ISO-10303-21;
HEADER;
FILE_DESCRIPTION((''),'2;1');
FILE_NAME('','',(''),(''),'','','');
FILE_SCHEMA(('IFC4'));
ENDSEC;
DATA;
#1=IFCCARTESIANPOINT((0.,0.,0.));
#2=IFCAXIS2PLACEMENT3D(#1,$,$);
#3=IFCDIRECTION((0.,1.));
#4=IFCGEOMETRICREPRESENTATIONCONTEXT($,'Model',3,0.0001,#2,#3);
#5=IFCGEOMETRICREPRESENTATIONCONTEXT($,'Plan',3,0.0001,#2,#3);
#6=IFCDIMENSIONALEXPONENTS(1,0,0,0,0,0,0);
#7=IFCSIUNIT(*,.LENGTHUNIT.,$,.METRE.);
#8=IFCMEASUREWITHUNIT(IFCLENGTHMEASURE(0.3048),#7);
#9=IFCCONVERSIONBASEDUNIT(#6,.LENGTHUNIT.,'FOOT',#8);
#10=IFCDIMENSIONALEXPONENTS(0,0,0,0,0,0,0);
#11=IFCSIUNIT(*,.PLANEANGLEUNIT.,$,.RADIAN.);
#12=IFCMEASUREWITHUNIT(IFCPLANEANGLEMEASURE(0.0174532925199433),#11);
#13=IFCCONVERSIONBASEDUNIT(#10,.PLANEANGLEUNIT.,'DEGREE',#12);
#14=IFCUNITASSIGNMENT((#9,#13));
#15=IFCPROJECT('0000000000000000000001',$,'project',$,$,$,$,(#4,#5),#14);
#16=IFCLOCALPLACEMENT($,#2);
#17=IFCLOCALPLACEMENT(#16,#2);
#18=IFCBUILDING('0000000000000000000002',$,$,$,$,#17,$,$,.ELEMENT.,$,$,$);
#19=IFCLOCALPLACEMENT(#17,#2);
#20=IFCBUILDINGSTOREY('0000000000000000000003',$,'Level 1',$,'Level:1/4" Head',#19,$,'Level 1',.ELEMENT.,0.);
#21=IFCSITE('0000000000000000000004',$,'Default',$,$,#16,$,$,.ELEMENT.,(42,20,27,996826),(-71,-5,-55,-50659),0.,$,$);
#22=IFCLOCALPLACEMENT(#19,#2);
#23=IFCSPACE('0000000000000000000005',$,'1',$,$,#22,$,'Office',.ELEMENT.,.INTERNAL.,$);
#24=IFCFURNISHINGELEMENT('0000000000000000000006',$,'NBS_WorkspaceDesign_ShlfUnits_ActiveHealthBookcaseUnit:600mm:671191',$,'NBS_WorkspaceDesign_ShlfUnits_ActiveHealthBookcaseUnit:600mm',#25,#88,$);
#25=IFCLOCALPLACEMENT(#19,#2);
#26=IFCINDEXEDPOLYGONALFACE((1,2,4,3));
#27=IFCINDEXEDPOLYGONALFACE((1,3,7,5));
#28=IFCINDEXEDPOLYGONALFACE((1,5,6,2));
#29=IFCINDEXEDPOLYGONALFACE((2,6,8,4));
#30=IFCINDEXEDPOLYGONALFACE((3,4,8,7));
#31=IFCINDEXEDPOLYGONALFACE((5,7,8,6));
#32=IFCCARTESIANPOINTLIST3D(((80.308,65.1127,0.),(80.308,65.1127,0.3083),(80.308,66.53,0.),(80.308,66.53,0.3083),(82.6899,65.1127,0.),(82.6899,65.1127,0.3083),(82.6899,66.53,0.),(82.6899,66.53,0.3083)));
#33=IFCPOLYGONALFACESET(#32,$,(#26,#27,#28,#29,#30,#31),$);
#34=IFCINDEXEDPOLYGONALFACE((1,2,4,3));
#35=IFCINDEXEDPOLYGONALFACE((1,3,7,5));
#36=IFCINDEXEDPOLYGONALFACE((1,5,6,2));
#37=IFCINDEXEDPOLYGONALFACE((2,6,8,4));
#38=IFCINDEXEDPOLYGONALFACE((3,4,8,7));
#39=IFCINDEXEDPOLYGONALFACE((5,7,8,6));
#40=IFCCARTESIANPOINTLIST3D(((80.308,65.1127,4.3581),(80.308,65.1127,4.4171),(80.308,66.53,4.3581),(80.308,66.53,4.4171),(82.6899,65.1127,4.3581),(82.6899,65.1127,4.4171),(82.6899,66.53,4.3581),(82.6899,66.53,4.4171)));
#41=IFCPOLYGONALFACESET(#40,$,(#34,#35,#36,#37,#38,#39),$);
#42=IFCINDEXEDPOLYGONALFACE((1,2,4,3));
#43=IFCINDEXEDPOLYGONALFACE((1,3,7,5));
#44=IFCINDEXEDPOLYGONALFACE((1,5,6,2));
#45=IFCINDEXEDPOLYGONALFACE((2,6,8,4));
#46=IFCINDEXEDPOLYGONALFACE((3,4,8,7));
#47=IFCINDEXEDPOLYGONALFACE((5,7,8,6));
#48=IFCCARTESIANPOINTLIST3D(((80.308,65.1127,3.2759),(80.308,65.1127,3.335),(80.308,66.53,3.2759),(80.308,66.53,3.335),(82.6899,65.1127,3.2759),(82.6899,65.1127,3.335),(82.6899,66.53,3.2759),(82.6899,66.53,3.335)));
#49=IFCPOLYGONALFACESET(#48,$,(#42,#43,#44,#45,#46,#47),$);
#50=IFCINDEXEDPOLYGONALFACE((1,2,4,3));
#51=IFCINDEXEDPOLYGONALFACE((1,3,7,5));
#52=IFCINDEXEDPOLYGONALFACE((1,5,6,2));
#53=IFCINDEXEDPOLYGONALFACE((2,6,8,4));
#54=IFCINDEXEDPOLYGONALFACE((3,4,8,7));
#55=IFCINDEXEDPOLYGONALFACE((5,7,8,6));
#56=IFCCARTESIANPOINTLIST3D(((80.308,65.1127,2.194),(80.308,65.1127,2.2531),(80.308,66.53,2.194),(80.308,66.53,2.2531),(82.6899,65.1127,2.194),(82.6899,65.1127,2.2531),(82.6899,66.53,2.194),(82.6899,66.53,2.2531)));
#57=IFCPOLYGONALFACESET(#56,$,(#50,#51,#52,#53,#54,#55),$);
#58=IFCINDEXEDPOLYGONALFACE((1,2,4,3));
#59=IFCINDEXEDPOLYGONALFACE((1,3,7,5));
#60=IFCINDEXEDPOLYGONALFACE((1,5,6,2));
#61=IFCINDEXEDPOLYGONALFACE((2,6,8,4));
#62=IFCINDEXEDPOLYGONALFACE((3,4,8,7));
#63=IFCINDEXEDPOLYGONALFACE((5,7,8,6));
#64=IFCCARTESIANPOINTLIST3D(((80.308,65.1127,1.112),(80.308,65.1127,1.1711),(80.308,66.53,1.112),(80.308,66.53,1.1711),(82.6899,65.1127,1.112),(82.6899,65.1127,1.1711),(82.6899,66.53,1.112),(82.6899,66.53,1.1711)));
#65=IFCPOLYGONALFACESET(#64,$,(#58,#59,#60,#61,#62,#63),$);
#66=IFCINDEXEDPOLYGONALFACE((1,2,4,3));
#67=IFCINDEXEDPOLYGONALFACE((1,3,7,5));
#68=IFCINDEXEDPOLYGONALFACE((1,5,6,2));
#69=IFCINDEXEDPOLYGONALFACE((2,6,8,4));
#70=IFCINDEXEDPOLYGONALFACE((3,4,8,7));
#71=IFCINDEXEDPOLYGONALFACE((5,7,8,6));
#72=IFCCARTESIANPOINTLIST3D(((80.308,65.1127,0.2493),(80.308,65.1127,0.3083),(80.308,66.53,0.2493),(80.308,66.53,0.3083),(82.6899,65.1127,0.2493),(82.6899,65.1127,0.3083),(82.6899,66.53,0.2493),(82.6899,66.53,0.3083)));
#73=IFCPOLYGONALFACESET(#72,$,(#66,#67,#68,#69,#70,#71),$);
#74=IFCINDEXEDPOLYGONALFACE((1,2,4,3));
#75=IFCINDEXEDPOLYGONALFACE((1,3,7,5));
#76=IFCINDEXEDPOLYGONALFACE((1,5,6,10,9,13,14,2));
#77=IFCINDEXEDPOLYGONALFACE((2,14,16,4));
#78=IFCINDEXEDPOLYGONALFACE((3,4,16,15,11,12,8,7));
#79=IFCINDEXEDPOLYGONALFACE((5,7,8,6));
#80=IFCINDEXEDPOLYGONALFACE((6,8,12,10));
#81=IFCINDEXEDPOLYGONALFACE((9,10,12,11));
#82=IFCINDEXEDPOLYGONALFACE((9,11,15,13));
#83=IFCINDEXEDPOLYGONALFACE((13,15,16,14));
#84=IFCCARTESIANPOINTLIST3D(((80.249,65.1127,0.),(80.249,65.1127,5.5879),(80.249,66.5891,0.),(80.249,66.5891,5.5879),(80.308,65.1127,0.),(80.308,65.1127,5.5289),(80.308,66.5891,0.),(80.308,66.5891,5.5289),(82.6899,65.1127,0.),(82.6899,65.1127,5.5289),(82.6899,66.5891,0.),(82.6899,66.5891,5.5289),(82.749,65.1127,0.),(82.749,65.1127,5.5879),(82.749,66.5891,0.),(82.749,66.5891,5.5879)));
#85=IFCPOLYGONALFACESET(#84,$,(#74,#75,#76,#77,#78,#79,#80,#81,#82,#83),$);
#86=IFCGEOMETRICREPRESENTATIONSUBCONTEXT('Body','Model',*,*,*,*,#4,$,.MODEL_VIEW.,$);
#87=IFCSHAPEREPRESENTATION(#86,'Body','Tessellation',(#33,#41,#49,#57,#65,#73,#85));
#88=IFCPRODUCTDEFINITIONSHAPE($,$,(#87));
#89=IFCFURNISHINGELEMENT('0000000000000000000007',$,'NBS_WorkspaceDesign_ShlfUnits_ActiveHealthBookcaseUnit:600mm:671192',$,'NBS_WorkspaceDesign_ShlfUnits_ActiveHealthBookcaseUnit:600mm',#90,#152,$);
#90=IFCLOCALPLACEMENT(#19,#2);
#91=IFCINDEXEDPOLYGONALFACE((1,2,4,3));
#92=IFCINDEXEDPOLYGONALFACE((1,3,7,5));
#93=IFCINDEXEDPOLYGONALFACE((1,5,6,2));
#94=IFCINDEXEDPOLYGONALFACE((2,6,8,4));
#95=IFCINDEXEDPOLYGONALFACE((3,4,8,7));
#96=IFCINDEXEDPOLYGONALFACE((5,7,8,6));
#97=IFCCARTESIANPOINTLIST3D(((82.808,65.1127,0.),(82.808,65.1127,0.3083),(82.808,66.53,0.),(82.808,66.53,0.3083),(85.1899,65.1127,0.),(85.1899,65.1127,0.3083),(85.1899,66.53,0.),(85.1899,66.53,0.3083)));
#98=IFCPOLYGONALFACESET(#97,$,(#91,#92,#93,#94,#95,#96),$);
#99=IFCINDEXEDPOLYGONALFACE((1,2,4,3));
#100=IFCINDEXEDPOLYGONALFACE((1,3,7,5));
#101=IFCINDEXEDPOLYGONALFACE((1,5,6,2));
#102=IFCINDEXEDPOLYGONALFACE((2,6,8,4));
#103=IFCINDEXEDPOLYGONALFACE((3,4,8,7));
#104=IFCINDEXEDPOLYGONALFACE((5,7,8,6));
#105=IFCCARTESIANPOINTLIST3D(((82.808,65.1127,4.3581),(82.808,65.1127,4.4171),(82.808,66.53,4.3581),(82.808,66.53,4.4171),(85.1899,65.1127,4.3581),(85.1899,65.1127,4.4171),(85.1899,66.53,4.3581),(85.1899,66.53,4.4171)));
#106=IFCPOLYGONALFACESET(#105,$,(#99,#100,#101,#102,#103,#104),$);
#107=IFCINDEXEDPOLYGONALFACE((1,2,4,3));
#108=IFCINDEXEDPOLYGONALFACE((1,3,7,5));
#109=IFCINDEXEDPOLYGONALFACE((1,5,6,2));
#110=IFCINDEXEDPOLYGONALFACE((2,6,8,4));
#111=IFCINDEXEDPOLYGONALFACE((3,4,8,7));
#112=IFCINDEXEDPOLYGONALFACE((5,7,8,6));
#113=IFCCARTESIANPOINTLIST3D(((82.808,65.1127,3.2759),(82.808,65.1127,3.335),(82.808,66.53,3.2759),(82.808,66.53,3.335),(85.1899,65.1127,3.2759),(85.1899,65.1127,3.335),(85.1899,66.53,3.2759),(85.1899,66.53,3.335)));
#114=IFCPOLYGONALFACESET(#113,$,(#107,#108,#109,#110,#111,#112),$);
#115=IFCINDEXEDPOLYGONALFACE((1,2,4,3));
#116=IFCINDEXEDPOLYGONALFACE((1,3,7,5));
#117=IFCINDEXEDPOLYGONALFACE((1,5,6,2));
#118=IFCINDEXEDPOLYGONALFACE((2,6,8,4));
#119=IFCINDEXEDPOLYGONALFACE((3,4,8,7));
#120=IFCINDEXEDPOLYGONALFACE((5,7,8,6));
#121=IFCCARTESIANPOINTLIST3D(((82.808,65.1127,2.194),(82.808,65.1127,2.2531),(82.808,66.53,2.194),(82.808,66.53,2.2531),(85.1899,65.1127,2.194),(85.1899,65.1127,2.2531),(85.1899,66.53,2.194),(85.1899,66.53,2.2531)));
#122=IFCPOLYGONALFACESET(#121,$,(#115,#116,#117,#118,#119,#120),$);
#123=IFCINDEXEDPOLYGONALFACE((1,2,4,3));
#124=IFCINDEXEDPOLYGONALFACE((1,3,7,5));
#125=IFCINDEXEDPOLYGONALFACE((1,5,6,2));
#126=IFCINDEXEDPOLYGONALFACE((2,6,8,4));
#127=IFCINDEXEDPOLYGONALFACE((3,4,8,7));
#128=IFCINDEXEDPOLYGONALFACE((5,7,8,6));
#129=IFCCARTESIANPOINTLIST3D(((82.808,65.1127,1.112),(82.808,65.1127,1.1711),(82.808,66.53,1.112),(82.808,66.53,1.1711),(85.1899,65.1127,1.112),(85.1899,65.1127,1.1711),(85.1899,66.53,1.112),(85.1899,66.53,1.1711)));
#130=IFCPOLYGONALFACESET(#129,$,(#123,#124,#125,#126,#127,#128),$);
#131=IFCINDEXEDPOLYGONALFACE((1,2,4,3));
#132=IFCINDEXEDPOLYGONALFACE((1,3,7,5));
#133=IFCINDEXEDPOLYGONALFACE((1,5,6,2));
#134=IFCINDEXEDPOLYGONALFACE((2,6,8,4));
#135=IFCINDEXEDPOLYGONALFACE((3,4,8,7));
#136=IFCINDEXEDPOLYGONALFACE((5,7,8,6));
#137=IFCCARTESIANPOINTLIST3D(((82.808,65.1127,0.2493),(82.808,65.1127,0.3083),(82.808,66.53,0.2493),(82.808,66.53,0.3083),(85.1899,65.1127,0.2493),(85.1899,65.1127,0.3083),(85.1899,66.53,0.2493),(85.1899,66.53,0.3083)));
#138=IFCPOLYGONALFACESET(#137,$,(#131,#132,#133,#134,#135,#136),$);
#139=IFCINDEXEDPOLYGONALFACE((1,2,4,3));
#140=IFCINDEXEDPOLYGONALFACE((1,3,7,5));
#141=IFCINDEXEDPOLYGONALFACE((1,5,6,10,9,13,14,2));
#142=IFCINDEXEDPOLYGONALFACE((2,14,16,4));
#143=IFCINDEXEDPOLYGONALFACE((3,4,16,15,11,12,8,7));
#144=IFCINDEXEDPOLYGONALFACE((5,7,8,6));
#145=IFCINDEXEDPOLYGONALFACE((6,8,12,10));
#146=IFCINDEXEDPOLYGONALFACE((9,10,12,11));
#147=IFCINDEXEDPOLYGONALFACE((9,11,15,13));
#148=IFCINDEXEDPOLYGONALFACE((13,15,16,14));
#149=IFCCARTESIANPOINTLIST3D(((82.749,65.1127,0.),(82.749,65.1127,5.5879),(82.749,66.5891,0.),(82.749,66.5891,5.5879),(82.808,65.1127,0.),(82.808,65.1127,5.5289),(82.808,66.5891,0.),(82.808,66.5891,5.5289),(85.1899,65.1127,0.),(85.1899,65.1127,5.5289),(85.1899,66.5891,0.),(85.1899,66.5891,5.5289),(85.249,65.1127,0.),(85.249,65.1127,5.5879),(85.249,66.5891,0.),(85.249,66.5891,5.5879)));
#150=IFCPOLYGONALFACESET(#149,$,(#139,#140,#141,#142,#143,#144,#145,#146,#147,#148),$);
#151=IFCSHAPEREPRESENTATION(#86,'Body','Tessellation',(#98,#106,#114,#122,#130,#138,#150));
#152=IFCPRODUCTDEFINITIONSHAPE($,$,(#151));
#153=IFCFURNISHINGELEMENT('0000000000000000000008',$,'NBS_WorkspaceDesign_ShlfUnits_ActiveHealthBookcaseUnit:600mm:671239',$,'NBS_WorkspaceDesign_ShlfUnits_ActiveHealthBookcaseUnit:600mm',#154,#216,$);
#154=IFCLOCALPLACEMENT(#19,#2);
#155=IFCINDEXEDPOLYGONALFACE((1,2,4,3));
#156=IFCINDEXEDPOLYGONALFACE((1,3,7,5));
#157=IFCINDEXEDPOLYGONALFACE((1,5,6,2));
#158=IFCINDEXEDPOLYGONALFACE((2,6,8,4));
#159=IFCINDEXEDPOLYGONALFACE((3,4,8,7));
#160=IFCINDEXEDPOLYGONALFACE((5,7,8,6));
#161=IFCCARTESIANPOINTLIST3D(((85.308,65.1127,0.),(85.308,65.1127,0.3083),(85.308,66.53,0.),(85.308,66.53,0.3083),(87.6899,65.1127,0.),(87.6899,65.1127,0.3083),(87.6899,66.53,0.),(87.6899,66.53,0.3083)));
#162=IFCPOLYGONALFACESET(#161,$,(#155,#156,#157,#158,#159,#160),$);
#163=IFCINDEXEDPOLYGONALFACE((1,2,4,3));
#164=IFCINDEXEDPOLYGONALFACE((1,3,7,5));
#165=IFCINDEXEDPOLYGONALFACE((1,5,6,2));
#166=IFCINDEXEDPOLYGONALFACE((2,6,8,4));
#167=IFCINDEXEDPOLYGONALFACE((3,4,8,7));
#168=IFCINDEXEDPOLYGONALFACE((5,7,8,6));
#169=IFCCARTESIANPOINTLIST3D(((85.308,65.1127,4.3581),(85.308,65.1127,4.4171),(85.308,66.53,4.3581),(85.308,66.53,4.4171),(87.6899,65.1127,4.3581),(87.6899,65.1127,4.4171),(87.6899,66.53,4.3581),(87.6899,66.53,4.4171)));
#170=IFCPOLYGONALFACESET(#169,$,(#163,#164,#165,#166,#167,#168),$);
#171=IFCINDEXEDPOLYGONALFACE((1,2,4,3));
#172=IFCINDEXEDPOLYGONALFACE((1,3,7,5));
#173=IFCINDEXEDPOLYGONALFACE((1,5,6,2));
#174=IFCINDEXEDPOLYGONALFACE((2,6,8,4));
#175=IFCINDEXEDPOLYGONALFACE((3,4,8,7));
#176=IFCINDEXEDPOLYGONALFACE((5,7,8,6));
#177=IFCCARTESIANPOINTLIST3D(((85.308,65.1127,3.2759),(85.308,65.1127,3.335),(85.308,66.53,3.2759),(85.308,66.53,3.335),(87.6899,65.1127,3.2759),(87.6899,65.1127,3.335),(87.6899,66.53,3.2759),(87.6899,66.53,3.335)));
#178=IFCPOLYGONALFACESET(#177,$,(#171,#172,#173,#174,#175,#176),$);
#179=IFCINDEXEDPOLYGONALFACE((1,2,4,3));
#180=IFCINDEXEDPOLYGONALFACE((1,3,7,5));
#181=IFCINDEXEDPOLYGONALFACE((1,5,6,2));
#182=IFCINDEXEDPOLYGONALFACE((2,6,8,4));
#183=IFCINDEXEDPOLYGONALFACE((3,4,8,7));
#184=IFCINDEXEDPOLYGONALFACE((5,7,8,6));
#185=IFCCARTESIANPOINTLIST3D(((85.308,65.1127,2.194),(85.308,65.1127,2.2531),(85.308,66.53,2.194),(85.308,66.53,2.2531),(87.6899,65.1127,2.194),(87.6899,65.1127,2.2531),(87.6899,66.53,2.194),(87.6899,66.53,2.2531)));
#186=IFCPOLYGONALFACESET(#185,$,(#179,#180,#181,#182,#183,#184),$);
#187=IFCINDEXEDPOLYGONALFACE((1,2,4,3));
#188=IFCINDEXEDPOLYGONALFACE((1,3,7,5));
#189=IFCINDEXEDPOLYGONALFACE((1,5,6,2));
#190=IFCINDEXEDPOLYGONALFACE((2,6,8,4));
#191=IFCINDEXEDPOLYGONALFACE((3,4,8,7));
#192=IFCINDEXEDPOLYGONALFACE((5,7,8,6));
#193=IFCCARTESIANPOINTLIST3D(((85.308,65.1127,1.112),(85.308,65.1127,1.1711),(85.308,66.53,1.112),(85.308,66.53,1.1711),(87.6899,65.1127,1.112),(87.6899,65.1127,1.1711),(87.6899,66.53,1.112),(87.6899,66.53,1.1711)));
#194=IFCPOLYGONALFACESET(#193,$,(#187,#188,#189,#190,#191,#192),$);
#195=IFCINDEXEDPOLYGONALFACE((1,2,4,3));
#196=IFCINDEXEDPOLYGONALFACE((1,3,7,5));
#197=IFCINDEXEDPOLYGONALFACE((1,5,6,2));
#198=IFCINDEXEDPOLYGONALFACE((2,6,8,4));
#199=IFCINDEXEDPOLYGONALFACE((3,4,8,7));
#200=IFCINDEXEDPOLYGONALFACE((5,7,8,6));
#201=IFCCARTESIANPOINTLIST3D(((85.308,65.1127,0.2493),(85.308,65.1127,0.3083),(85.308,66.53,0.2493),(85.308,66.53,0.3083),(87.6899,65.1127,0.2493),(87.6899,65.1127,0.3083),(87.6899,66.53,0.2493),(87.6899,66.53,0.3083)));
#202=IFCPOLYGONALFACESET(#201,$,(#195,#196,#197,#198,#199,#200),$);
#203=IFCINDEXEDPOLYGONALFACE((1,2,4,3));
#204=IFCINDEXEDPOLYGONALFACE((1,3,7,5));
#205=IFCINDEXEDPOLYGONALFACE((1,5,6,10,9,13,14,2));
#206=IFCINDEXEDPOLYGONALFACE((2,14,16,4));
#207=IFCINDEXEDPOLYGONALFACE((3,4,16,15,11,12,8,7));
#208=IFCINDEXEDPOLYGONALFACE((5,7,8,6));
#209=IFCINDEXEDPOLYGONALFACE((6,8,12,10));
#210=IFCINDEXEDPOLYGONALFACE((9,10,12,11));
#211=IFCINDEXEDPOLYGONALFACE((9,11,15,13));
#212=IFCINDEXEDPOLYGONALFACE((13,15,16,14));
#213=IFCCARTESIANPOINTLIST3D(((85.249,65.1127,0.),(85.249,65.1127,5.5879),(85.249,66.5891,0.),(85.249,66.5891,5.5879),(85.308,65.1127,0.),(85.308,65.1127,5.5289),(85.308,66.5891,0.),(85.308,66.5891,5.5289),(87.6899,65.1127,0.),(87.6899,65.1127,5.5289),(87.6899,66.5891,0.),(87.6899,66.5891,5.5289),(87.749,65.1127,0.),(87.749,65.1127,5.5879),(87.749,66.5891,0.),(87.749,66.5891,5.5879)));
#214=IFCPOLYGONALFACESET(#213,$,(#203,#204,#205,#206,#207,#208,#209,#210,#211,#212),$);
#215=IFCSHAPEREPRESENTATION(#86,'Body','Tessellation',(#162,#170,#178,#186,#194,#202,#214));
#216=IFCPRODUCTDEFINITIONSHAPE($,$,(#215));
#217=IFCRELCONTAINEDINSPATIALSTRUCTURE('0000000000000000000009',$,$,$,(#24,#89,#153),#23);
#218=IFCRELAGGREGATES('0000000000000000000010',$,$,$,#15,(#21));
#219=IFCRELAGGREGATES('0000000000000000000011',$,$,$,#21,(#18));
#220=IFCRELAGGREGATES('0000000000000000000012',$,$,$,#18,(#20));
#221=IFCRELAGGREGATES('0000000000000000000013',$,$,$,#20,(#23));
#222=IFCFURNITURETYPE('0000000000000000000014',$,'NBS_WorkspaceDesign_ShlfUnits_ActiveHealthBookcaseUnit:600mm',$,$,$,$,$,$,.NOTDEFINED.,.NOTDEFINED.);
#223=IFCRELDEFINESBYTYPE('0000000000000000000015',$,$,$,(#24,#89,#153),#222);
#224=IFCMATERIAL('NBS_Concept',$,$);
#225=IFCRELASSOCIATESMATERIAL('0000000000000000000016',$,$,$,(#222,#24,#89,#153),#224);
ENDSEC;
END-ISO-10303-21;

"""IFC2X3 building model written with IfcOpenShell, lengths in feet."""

from ifc_helpers import new_model, entity, si_unit, converted_unit, direction, frame, frame_2d, origin, place, context, subcontext, project, spatial, polyline, rectangle, outline, extrude, source, transform, mapped, material, type_object, type_shapes, element, save


model = new_model("IFC2X3")

# Units and contexts
model_context = context("Model", 3, precision=0.0001, world=origin(), true_north=direction((0.0, 1.0)))
plan_context = context("Plan", 3, precision=0.0001, world=origin(), true_north=direction((0.0, 1.0)))
body_context = subcontext(model_context, "Body", "Model", "MODEL_VIEW")
ifc_project = project(units=[converted_unit("LENGTHUNIT", "FOOT", entity("IfcLengthMeasure", 0.3048), si_unit("LENGTHUNIT", "METRE"), dimensions=[1, 0, 0, 0, 0, 0, 0]), converted_unit("PLANEANGLEUNIT", "DEGREE", entity("IfcPlaneAngleMeasure", 0.0174532925199433), si_unit("PLANEANGLEUNIT", "RADIAN"), dimensions=[0, 0, 0, 0, 0, 0, 0])], contexts=[model_context, plan_context])

# Site, building, storey
site_placement = place(None, origin())
site = spatial("IfcSite", under=ifc_project, at=site_placement, Name="Default", CompositionType="ELEMENT", RefLatitude=(42, 20, 27, 996826), RefLongitude=(-71, -5, -55, -50659), RefElevation=0.0)
building_placement = place(site_placement, origin())
building = spatial("IfcBuilding", under=site, at=building_placement, CompositionType="ELEMENT")
storey_placement = place(building_placement, origin())
storey = spatial("IfcBuildingStorey", under=building, at=storey_placement, Name="Level 1", ObjectType="Level:1/4\" Head", LongName="Level 1", CompositionType="ELEMENT", Elevation=0.0)

# Shared definitions
ifc_material_1 = material(Name="NBS_Concept")

# Shared definitions
space_1_placement = place(storey_placement, origin())
space_1 = spatial("IfcSpace", under=storey, at=space_1_placement, Name="1", LongName="Office", CompositionType="ELEMENT", InteriorOrExteriorSpace="INTERNAL")

# Furnishing elements
furniture_type = type_object("IfcFurnitureType", Name="NBS_WorkspaceDesign_ShlfUnits_ActiveHealthBookcaseUnit:600mm", AssemblyPlace="NOTDEFINED", material=ifc_material_1)
shared_shape_1 = source(origin(), body_context, "Body", "SweptSolid", [
    extrude(rectangle(XDim=1.4173, YDim=2.3819, at=frame_2d((0.0, 0.0), x_axis=(1.0, 0.0))), frame((0.0, -0.7677, 0.0), z_axis=(0.0, 0.0, 1.0), x_axis=(0.0, 1.0, 0.0)), (0.0, 0.0, 1.0), 0.3083),
    extrude(rectangle(XDim=1.4173, YDim=2.3819, at=frame_2d((0.0, 0.0), x_axis=(1.0, 0.0))), frame((0.0, -0.7677, 4.3581), z_axis=(0.0, 0.0, 1.0), x_axis=(0.0, 1.0, 0.0)), (0.0, 0.0, 1.0), 0.0591),
    extrude(rectangle(XDim=1.4173, YDim=2.3819, at=frame_2d((0.0, 0.0), x_axis=(1.0, 0.0))), frame((0.0, -0.7677, 3.2759), z_axis=(0.0, 0.0, 1.0), x_axis=(0.0, 1.0, 0.0)), (0.0, 0.0, 1.0), 0.0591),
    extrude(rectangle(XDim=1.4173, YDim=2.3819, at=frame_2d((0.0, 0.0), x_axis=(1.0, 0.0))), frame((0.0, -0.7677, 2.194), z_axis=(0.0, 0.0, 1.0), x_axis=(0.0, 1.0, 0.0)), (0.0, 0.0, 1.0), 0.0591),
    extrude(rectangle(XDim=1.4173, YDim=2.3819, at=frame_2d((0.0, 0.0), x_axis=(1.0, 0.0))), frame((0.0, -0.7677, 1.112), z_axis=(0.0, 0.0, 1.0), x_axis=(0.0, 1.0, 0.0)), (0.0, 0.0, 1.0), 0.0591),
    extrude(rectangle(XDim=1.4173, YDim=2.3819, at=frame_2d((0.0, 0.0), x_axis=(1.0, 0.0))), frame((0.0, -0.7677, 0.2493), z_axis=(0.0, 0.0, 1.0), x_axis=(0.0, 1.0, 0.0)), (0.0, 0.0, 1.0), 0.0591),
    extrude(outline(polyline([(-2.8087, -1.25), (2.7792, -1.25), (2.7792, -1.1909), (-2.7497, -1.1909), (-2.7497, 1.1909), (2.7792, 1.1909), (2.7792, 1.25), (-2.8087, 1.25), (-2.8087, -1.25)])), frame((0.0, -1.4764, 2.7792), z_axis=(0.0, 1.0, 0.0), x_axis=(0.0, 0.0, -1.0)), (0.0, 0.0, 1.0), 1.4764),
])
type_shapes(furniture_type, [shared_shape_1])
for number, where, name in (
    (1, (81.499, 66.5891, 0.0), "NBS_WorkspaceDesign_ShlfUnits_ActiveHealthBookcaseUnit:600mm:671191"),
    (2, (83.999, 66.5891, 0.0), "NBS_WorkspaceDesign_ShlfUnits_ActiveHealthBookcaseUnit:600mm:671192"),
    (3, (86.499, 66.5891, 0.0), "NBS_WorkspaceDesign_ShlfUnits_ActiveHealthBookcaseUnit:600mm:671239"),
):
    element("IfcFurnishingElement", number, at=place(space_1_placement, frame(where)), inside=space_1, type_object=furniture_type, material=ifc_material_1, Name=name, ObjectType="NBS_WorkspaceDesign_ShlfUnits_ActiveHealthBookcaseUnit:600mm", context=body_context, shape_type="MappedRepresentation", body=[
        mapped(shared_shape_1, transform((0.0, 0.0, 0.0), scale=1.0)),
    ])

save(model, "model.ifc")
